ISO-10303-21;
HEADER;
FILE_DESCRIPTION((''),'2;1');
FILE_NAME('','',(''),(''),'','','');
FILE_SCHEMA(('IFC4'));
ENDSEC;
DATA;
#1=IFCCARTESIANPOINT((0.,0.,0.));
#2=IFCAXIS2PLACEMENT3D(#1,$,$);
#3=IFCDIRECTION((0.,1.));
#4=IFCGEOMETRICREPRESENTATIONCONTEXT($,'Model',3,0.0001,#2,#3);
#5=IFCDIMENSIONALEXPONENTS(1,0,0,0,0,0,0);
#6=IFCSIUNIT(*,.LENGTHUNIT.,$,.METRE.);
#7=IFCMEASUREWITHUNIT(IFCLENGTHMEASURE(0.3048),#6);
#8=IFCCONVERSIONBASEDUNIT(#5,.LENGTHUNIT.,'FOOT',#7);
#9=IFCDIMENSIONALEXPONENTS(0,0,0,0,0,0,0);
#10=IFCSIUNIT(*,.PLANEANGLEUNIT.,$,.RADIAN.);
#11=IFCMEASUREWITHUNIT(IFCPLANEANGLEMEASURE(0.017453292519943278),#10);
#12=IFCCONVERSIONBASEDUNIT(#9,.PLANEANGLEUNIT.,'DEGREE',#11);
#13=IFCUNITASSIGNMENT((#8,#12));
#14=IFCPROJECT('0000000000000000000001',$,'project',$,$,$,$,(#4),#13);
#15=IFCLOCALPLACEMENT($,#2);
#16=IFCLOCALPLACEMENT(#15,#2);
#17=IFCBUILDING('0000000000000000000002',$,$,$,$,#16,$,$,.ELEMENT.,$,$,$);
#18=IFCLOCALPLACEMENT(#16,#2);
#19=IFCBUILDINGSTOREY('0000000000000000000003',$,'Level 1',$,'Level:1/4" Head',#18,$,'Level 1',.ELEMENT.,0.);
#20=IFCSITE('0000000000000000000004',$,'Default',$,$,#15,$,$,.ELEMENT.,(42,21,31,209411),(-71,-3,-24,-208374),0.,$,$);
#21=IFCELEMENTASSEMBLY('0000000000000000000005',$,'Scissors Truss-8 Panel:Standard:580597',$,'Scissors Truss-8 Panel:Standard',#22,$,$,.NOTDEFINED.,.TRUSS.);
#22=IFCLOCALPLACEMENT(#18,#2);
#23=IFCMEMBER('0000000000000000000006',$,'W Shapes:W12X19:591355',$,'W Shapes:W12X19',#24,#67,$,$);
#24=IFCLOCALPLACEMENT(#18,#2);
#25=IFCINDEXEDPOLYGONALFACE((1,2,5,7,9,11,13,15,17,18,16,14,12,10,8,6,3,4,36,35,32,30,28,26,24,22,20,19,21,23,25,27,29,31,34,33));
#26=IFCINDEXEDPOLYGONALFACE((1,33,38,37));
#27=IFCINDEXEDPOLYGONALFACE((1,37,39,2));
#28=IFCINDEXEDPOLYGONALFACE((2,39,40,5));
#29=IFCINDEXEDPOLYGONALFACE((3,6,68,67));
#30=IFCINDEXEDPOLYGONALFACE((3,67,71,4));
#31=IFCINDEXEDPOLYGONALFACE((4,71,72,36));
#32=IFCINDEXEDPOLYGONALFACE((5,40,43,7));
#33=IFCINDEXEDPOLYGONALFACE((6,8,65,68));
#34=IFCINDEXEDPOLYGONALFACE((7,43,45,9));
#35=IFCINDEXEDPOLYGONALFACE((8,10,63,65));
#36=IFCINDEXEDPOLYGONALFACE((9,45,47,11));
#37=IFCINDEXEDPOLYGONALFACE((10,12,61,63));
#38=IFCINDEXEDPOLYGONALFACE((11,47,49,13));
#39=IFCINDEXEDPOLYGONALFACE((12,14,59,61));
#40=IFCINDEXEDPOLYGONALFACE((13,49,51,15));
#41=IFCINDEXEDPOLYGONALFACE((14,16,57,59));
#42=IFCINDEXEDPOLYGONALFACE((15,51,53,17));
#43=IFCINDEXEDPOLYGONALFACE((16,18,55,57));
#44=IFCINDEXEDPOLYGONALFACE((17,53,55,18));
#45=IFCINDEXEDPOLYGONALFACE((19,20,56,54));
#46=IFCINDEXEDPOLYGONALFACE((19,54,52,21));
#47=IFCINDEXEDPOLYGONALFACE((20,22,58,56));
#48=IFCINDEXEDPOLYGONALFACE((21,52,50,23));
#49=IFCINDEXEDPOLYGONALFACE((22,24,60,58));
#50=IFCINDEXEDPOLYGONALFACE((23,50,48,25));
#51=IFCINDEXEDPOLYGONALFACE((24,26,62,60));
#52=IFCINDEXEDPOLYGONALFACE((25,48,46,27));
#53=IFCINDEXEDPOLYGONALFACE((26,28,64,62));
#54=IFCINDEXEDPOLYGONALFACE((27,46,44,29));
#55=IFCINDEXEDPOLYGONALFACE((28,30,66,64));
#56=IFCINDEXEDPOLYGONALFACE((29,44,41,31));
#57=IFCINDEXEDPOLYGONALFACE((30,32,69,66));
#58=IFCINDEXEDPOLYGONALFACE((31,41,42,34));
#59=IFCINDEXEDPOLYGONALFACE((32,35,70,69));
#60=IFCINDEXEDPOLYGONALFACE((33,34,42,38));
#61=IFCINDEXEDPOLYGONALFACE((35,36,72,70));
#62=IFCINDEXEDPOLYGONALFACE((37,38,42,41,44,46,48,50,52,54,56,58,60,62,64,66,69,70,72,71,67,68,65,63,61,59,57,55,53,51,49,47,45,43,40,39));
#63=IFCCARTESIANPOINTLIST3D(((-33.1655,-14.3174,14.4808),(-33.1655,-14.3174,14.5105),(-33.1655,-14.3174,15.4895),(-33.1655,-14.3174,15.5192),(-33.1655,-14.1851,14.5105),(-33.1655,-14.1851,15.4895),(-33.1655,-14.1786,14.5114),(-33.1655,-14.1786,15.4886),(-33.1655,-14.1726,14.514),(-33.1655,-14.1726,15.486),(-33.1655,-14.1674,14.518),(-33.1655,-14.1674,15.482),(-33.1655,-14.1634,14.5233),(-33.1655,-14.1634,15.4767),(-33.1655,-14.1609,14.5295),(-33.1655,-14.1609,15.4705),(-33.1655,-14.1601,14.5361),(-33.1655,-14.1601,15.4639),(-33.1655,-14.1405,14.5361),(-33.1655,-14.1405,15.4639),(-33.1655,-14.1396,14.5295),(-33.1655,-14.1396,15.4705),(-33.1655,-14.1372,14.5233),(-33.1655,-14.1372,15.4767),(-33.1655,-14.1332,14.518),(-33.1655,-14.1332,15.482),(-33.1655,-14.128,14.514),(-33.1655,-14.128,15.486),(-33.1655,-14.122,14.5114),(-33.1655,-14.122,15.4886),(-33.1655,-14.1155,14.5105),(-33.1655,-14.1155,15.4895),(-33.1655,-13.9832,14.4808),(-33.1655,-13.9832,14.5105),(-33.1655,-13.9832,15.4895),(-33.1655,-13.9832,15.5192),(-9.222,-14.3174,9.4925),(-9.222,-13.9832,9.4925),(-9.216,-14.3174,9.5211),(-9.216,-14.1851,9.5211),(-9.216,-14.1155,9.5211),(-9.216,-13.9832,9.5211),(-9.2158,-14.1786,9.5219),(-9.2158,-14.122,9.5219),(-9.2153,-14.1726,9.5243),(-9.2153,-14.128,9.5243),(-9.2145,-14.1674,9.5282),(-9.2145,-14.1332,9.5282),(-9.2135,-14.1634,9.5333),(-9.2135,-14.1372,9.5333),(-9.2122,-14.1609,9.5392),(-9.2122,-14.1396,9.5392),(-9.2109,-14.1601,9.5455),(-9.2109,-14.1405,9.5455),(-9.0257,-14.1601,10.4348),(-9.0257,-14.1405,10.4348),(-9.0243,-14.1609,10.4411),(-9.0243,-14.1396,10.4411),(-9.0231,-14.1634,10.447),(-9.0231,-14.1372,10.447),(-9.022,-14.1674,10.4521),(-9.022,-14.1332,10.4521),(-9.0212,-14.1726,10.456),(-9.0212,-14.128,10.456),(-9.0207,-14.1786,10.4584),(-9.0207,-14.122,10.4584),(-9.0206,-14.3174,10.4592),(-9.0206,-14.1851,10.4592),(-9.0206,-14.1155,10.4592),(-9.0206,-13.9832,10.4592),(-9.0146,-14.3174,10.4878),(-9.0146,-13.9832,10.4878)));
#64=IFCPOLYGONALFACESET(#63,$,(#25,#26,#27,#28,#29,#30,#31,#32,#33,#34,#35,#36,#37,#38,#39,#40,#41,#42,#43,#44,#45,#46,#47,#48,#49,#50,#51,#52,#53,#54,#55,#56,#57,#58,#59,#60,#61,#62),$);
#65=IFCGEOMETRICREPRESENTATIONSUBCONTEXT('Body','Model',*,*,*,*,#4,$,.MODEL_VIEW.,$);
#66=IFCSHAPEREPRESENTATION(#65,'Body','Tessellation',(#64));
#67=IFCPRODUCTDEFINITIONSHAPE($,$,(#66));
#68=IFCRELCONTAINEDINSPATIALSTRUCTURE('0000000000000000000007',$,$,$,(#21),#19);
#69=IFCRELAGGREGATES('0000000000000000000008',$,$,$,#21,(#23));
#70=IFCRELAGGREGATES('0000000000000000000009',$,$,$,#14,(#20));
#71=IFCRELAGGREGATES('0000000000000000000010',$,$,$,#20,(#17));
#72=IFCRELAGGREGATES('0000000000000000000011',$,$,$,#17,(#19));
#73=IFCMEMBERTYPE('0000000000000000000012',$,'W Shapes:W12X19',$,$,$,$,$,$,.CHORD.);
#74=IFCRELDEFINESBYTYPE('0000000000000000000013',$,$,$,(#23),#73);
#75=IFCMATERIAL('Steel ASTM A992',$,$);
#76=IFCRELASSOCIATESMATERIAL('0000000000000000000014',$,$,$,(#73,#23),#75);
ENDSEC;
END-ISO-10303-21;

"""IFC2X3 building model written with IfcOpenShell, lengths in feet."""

from ifc_helpers import new_model, entity, si_unit, converted_unit, direction, frame, frame_2d, origin, place, context, subcontext, project, spatial, i_section, extrude, clip, halfspace, source, transform, mapped, material, type_object, type_shapes, element, aggregate, save


model = new_model("IFC2X3")

# Units and contexts
model_context = context("Model", 3, precision=0.0001, world=origin(), true_north=direction((0.0, 1.0)))
body_context = subcontext(model_context, "Body", "Model", "MODEL_VIEW")
ifc_project = project(units=[converted_unit("LENGTHUNIT", "FOOT", entity("IfcLengthMeasure", 0.3048), si_unit("LENGTHUNIT", "METRE"), dimensions=[1, 0, 0, 0, 0, 0, 0]), converted_unit("PLANEANGLEUNIT", "DEGREE", entity("IfcPlaneAngleMeasure", 0.017453292519943278), si_unit("PLANEANGLEUNIT", "RADIAN"), dimensions=[0, 0, 0, 0, 0, 0, 0])], contexts=[model_context])

# Site, building, storey
site_placement = place(None, origin())
site = spatial("IfcSite", under=ifc_project, at=site_placement, Name="Default", CompositionType="ELEMENT", RefLatitude=(42, 21, 31, 209411), RefLongitude=(-71, -3, -24, -208374), RefElevation=0.0)
building_placement = place(site_placement, origin())
building = spatial("IfcBuilding", under=site, at=building_placement, CompositionType="ELEMENT")
storey_placement = place(building_placement, origin())
storey = spatial("IfcBuildingStorey", under=building, at=storey_placement, Name="Level 1", ObjectType="Level:1/4\" Head", LongName="Level 1", CompositionType="ELEMENT", Elevation=0.0)

# Element assembly, member
assembly_placement = place(storey_placement, origin())
assembly = element("IfcElementAssembly", 1, at=assembly_placement, inside=storey, Name="Scissors Truss-8 Panel:Standard:580597", ObjectType="Scissors Truss-8 Panel:Standard", AssemblyPlace="NOTDEFINED", PredefinedType="TRUSS")
ifc_material = material(Name="Steel ASTM A992")
member_type_1 = type_object("IfcMemberType", Name="W Shapes:W12X19", PredefinedType="CHORD", material=ifc_material)
shared_shape_1 = source(origin(), body_context, "Body", "Clipping", [
    clip(extrude(i_section(OverallWidth=0.3342, OverallDepth=1.0167, WebThickness=0.0196, FlangeThickness=0.0292, FilletRadius=0.025, at=frame_2d((0.0, 0.0), x_axis=(1.0, 0.0))), frame((-33.2692, -14.1503, 15.0216), z_axis=(0.97898, 0.0, -0.203954), x_axis=(0.0, 1.0, 0.0)), (0.0, 0.0, 1.0), 24.6695), halfspace(frame((-33.1655, -14.1503, 15.5192), z_axis=(-1.0, 0.0, 0.0), x_axis=(0.0, 1.0, 0.0)), False)),
])
type_shapes(member_type_1, [shared_shape_1])
member_1_placement = place(assembly_placement, origin())
member_1 = element("IfcMember", 2, at=member_1_placement, type_object=member_type_1, material=ifc_material, Name="W Shapes:W12X19:591355", ObjectType="W Shapes:W12X19", context=body_context, shape_type="MappedRepresentation", body=[
    mapped(shared_shape_1, transform((0.0, 0.0, 0.0), scale=1.0)),
])
aggregate(assembly, [member_1])

save(model, "model.ifc")
